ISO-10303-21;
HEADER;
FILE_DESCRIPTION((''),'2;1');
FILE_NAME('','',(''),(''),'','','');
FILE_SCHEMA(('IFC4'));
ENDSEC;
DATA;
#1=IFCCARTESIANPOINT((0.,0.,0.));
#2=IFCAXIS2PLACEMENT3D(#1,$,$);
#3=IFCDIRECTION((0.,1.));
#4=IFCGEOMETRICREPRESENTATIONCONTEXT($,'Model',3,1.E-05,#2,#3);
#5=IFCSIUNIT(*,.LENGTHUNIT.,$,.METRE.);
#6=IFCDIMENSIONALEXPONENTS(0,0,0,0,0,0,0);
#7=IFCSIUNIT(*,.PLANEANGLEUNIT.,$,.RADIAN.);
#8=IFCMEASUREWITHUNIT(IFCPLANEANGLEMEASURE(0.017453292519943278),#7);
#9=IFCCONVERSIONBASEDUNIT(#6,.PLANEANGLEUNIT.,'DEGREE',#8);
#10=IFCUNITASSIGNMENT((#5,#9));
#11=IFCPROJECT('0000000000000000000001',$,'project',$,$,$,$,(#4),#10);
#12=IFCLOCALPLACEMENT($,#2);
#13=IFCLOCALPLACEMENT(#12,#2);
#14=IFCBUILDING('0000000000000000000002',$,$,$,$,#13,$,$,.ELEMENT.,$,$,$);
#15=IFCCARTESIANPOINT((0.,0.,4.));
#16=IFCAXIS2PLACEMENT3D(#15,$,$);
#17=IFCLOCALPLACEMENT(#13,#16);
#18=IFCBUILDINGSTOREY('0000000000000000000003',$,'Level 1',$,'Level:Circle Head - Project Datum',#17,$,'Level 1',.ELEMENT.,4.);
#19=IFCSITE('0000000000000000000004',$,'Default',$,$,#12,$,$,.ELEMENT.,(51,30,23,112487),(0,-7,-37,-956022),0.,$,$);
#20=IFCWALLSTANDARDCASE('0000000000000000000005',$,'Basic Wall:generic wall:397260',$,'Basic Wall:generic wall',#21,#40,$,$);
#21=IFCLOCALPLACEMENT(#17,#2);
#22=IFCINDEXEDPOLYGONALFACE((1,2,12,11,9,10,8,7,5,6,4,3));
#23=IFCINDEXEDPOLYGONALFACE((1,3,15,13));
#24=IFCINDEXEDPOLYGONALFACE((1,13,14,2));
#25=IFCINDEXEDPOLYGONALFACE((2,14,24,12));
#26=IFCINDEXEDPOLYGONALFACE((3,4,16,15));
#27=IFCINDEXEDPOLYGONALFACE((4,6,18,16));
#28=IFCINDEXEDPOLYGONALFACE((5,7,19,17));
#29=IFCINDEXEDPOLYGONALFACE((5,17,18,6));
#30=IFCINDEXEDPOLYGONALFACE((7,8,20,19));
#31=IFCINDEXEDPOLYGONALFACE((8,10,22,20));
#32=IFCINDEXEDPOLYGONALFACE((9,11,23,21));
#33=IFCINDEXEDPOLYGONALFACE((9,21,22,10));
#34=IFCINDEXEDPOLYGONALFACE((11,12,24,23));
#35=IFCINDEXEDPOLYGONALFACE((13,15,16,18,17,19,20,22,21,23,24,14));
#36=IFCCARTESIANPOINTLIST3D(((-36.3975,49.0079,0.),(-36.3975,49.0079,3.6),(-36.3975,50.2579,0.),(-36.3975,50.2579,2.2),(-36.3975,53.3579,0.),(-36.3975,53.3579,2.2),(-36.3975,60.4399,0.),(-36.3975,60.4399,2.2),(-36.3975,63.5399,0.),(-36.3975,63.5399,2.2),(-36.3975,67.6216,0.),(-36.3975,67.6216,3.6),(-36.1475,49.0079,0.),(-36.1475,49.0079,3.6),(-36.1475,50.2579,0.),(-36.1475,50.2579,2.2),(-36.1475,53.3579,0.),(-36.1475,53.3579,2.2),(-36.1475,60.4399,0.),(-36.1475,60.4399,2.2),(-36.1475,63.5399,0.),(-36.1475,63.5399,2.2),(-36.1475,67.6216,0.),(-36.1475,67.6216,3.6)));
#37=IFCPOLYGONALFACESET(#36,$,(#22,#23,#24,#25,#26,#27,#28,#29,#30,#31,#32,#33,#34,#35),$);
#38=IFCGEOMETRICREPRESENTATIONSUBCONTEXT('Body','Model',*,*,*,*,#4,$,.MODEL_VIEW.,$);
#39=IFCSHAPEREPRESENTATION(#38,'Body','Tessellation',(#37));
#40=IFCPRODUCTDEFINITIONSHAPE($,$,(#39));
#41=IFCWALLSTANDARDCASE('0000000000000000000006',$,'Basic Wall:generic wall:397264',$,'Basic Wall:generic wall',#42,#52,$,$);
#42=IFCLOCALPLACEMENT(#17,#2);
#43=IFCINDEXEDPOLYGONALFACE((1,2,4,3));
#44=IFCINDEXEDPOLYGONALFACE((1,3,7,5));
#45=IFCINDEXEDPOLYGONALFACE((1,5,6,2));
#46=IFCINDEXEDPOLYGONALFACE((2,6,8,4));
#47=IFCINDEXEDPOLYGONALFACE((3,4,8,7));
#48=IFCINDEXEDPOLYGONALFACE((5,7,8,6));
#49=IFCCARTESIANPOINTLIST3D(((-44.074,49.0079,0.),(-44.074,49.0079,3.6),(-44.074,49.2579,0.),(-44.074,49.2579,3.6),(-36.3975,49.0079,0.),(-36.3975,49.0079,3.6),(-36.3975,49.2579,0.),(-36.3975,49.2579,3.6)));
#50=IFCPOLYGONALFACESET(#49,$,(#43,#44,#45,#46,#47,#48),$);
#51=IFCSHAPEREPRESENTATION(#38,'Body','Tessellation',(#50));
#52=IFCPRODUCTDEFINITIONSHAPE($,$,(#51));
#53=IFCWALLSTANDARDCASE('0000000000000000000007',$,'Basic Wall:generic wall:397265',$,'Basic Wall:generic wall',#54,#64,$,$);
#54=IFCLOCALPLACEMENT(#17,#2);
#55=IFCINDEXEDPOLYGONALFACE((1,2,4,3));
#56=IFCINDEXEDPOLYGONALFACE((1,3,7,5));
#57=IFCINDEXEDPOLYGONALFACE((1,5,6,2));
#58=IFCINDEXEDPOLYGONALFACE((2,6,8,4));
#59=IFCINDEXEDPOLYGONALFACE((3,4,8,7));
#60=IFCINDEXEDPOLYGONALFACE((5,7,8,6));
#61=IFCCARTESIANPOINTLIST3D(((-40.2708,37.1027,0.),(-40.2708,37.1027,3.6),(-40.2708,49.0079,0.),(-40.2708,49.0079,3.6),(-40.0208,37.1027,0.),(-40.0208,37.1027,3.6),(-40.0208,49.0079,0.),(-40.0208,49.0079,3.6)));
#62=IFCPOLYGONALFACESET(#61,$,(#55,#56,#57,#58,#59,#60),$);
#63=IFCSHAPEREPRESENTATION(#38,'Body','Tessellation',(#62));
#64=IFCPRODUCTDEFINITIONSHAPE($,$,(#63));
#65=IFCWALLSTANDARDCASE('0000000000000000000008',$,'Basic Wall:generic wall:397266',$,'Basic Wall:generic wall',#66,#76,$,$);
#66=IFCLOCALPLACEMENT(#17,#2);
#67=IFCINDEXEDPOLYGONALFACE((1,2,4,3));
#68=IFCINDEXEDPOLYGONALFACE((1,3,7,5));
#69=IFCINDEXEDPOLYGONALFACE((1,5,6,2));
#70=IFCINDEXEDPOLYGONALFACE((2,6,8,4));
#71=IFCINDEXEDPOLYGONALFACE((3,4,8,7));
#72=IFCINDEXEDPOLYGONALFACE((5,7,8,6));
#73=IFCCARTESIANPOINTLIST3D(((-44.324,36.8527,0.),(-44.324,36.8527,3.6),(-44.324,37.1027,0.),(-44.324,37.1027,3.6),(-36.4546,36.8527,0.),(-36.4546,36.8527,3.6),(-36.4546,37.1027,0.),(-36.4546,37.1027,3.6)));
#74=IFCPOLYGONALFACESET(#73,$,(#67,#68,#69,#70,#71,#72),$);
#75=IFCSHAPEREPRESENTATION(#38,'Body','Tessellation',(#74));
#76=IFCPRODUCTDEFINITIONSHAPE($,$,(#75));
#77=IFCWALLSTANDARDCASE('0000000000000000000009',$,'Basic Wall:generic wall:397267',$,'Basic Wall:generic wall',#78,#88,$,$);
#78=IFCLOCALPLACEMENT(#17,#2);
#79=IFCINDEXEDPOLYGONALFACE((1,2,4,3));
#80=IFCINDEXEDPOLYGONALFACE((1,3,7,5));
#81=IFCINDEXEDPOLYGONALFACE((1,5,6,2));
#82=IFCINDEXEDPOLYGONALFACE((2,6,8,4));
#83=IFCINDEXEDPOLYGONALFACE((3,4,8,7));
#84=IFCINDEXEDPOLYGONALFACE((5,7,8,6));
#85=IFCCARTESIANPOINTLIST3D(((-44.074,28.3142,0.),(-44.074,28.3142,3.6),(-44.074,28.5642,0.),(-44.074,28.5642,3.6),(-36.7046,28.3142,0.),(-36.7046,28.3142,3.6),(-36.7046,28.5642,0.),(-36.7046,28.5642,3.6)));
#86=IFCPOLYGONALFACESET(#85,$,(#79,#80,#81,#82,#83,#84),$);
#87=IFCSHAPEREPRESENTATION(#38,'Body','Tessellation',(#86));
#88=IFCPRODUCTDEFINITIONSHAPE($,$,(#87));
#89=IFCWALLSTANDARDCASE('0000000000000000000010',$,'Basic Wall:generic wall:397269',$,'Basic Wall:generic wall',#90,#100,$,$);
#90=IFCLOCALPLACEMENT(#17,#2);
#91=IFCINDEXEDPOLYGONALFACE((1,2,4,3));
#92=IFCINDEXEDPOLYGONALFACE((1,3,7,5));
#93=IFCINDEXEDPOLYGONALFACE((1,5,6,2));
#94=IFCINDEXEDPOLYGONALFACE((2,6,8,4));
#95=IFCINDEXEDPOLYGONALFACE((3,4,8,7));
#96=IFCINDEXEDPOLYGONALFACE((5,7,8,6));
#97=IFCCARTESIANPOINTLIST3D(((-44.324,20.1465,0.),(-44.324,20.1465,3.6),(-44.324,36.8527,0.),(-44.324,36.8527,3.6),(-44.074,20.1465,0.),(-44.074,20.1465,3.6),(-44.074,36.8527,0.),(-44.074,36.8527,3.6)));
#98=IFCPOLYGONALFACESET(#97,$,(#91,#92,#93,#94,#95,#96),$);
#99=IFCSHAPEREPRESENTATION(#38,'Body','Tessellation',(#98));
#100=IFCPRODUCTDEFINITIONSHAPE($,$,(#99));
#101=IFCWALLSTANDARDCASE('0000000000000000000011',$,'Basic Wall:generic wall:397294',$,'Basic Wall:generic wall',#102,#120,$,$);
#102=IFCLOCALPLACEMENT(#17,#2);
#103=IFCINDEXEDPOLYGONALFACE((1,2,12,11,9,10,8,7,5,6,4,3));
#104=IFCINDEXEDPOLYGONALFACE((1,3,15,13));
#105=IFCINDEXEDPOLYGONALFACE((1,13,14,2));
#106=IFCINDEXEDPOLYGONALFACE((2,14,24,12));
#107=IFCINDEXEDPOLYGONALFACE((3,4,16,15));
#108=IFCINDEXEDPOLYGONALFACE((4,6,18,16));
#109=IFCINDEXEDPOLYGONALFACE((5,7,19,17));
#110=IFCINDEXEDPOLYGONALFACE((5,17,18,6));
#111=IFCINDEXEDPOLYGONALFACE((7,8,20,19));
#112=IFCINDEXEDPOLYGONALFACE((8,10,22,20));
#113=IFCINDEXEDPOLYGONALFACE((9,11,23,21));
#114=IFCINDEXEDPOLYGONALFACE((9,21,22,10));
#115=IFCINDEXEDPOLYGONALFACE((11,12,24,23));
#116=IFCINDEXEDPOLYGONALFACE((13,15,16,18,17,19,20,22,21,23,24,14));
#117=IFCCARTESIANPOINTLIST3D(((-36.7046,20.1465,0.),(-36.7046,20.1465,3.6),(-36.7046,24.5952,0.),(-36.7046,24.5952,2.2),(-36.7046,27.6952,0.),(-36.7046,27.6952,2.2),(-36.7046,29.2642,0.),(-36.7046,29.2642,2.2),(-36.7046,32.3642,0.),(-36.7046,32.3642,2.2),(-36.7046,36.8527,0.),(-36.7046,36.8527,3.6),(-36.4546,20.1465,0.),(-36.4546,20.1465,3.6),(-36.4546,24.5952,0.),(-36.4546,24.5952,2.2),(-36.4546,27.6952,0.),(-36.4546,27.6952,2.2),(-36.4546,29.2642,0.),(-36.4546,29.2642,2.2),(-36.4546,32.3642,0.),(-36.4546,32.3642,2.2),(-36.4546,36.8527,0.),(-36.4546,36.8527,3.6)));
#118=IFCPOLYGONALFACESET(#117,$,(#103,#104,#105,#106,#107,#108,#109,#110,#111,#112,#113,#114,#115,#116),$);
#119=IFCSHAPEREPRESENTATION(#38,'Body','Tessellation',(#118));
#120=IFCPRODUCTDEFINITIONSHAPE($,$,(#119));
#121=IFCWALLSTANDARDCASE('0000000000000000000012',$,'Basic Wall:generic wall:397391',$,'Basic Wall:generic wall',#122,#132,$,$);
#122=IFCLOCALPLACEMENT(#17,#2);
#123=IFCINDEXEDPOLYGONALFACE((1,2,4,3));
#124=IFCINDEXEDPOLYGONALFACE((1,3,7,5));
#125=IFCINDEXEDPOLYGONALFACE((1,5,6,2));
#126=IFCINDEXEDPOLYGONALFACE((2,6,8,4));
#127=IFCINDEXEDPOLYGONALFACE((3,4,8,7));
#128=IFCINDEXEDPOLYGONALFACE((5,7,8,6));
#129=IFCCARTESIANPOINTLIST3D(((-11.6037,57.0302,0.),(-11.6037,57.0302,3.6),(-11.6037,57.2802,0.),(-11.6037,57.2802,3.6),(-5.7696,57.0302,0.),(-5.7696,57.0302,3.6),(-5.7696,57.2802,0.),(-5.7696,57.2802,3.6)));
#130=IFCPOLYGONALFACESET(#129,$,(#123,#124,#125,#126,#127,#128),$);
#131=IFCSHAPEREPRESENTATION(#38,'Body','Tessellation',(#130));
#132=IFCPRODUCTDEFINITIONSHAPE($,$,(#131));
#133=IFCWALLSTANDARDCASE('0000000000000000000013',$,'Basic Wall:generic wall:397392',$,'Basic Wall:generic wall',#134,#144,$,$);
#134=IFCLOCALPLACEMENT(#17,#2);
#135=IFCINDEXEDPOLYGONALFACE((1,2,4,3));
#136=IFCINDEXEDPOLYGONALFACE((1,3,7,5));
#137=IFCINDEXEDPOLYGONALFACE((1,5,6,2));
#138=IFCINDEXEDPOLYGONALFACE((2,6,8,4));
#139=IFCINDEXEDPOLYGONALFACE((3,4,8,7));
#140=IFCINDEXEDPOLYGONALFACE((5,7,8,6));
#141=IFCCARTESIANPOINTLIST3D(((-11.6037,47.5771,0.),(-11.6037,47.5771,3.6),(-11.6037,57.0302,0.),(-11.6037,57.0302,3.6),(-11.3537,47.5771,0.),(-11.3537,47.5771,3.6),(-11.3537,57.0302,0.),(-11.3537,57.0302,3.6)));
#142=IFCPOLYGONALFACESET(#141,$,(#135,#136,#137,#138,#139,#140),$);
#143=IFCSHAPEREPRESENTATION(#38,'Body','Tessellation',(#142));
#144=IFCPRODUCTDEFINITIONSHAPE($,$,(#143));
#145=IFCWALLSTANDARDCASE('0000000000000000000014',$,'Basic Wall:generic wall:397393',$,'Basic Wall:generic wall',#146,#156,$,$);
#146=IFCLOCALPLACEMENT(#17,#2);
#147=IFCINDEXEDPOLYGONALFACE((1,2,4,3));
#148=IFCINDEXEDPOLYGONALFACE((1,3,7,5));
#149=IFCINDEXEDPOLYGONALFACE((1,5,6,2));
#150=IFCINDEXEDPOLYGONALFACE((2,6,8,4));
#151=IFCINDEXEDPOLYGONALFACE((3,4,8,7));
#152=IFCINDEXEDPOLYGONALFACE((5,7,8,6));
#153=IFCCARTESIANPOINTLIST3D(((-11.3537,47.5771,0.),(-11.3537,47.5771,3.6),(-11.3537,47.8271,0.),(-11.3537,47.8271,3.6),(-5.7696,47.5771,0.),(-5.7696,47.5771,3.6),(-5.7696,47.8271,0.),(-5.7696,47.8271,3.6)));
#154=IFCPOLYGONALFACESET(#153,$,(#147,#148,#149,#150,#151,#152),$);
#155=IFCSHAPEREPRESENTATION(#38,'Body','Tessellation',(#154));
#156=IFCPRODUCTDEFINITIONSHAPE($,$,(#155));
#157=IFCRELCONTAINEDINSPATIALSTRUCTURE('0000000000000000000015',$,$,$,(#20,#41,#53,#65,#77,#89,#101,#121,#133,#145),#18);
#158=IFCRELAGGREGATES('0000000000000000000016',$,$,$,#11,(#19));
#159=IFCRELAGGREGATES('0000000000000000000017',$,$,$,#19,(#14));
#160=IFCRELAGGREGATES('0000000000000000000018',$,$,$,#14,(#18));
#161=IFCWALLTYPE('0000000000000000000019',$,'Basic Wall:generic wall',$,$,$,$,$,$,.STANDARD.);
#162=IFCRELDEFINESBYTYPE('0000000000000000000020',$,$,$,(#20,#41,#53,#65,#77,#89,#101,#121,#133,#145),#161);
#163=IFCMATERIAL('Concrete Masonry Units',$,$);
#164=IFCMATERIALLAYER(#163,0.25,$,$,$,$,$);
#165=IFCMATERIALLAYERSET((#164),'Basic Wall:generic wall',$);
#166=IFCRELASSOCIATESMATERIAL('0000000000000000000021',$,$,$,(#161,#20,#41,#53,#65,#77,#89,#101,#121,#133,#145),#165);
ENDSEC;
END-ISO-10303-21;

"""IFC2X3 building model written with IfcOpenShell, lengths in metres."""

from ifc_helpers import new_model, entity, si_unit, converted_unit, direction, frame, frame_2d, origin, place, context, subcontext, project, spatial, rectangle, extrude, material, layer, layer_set, layer_usage, type_object, element, save


model = new_model("IFC2X3")

# Units and contexts
model_context = context("Model", 3, precision=1e-05, world=origin(), true_north=direction((0.0, 1.0)))
body_context = subcontext(model_context, "Body", "Model", "MODEL_VIEW")
ifc_project = project(units=[si_unit("LENGTHUNIT", "METRE"), converted_unit("PLANEANGLEUNIT", "DEGREE", entity("IfcPlaneAngleMeasure", 0.017453292519943278), si_unit("PLANEANGLEUNIT", "RADIAN"), dimensions=[0, 0, 0, 0, 0, 0, 0])], contexts=[model_context])

# Site, building, storey
site_placement = place(None, origin())
site = spatial("IfcSite", under=ifc_project, at=site_placement, Name="Default", CompositionType="ELEMENT", RefLatitude=(51, 30, 23, 112487), RefLongitude=(0, -7, -37, -956022), RefElevation=0.0)
building_placement = place(site_placement, origin())
building = spatial("IfcBuilding", under=site, at=building_placement, CompositionType="ELEMENT")
storey_placement = place(building_placement, frame((0.0, 0.0, 4.0)))
storey = spatial("IfcBuildingStorey", under=building, at=storey_placement, Name="Level 1", ObjectType="Level:Circle Head - Project Datum", LongName="Level 1", CompositionType="ELEMENT", Elevation=4.0)

# Wall, openings
ifc_material = material(Name="Concrete Masonry Units")
ifc_layer = layer(ifc_material, 0.25)
ifc_layer_set = layer_set([ifc_layer], Name="Basic Wall:generic wall")
ifc_layer_usage_1 = layer_usage(ifc_layer_set, "AXIS2", "NEGATIVE", 0.125)
wall_type = type_object("IfcWallType", Name="Basic Wall:generic wall", PredefinedType="STANDARD", material=ifc_layer_set)
wall_1_placement = place(storey_placement, frame((-36.2725, 49.0079, 0.0), z_axis=(0.0, 0.0, 1.0), x_axis=(0.0, 1.0, 0.0)))
wall_1 = element("IfcWallStandardCase", 1, at=wall_1_placement, inside=storey, type_object=wall_type, material=ifc_layer_usage_1, Name="Basic Wall:generic wall:397260", ObjectType="Basic Wall:generic wall", context=body_context, shape_type="SweptSolid", body=[
    extrude(rectangle(XDim=18.6137, YDim=0.25, at=frame_2d((9.3069, 0.0), x_axis=(-1.0, 0.0))), origin(), (0.0, 0.0, 1.0), 3.6),
])
opening_1_placement = place(wall_1_placement, frame((11.432, -0.125, 0.0)))
element("IfcOpeningElement", 2, at=opening_1_placement, cuts=wall_1, ObjectType="Opening", context=body_context, shape_type="SweptSolid", body=[
    extrude(rectangle(XDim=2.2, YDim=3.1, at=frame_2d((1.1, 1.55), x_axis=(1.0, 0.0))), frame((0.0, 0.0, 0.0), z_axis=(0.0, 1.0, 0.0), x_axis=(0.0, 0.0, 1.0)), (0.0, 0.0, 1.0), 0.25),
])
opening_2_placement = place(wall_1_placement, frame((1.25, -0.125, 0.0)))
element("IfcOpeningElement", 3, at=opening_2_placement, cuts=wall_1, ObjectType="Opening", context=body_context, shape_type="SweptSolid", body=[
    extrude(rectangle(XDim=2.2, YDim=3.1, at=frame_2d((1.1, 1.55), x_axis=(1.0, 0.0))), frame((0.0, 0.0, 0.0), z_axis=(0.0, 1.0, 0.0), x_axis=(0.0, 0.0, 1.0)), (0.0, 0.0, 1.0), 0.25),
])

# Walls
ifc_layer_usage_2 = layer_usage(ifc_layer_set, "AXIS2", "NEGATIVE", 0.125)
wall_2_placement = place(storey_placement, frame((-44.074, 49.1329, 0.0)))
element("IfcWallStandardCase", 4, at=wall_2_placement, inside=storey, type_object=wall_type, material=ifc_layer_usage_2, Name="Basic Wall:generic wall:397264", ObjectType="Basic Wall:generic wall", context=body_context, shape_type="SweptSolid", body=[
    extrude(rectangle(XDim=7.6765, YDim=0.25, at=frame_2d((3.8382, 0.0), x_axis=(-1.0, 0.0))), origin(), (0.0, 0.0, 1.0), 3.6),
])
ifc_layer_usage_3 = layer_usage(ifc_layer_set, "AXIS2", "NEGATIVE", 0.125)
wall_3_placement = place(storey_placement, frame((-40.1458, 49.0079, 0.0), z_axis=(0.0, 0.0, 1.0), x_axis=(0.0, -1.0, 0.0)))
element("IfcWallStandardCase", 5, at=wall_3_placement, inside=storey, type_object=wall_type, material=ifc_layer_usage_3, Name="Basic Wall:generic wall:397265", ObjectType="Basic Wall:generic wall", context=body_context, shape_type="SweptSolid", body=[
    extrude(rectangle(XDim=11.9052, YDim=0.25, at=frame_2d((5.9526, 0.0), x_axis=(-1.0, 0.0))), origin(), (0.0, 0.0, 1.0), 3.6),
])
ifc_layer_usage_4 = layer_usage(ifc_layer_set, "AXIS2", "NEGATIVE", 0.125)
wall_4_placement = place(storey_placement, frame((-36.4546, 36.9777, 0.0), z_axis=(0.0, 0.0, 1.0), x_axis=(-1.0, 0.0, 0.0)))
element("IfcWallStandardCase", 6, at=wall_4_placement, inside=storey, type_object=wall_type, material=ifc_layer_usage_4, Name="Basic Wall:generic wall:397266", ObjectType="Basic Wall:generic wall", context=body_context, shape_type="SweptSolid", body=[
    extrude(rectangle(XDim=7.8694, YDim=0.25, at=frame_2d((3.9347, 0.0), x_axis=(-1.0, 0.0))), origin(), (0.0, 0.0, 1.0), 3.6),
])
ifc_layer_usage_5 = layer_usage(ifc_layer_set, "AXIS2", "NEGATIVE", 0.125)
wall_5_placement = place(storey_placement, frame((-36.7046, 28.4392, 0.0), z_axis=(0.0, 0.0, 1.0), x_axis=(-1.0, 0.0, 0.0)))
element("IfcWallStandardCase", 7, at=wall_5_placement, inside=storey, type_object=wall_type, material=ifc_layer_usage_5, Name="Basic Wall:generic wall:397267", ObjectType="Basic Wall:generic wall", context=body_context, shape_type="SweptSolid", body=[
    extrude(rectangle(XDim=7.3694, YDim=0.25, at=frame_2d((3.6847, 0.0), x_axis=(-1.0, 0.0))), origin(), (0.0, 0.0, 1.0), 3.6),
])
ifc_layer_usage_6 = layer_usage(ifc_layer_set, "AXIS2", "NEGATIVE", 0.125)
wall_6_placement = place(storey_placement, frame((-44.199, 36.8527, 0.0), z_axis=(0.0, 0.0, 1.0), x_axis=(0.0, -1.0, 0.0)))
element("IfcWallStandardCase", 8, at=wall_6_placement, inside=storey, type_object=wall_type, material=ifc_layer_usage_6, Name="Basic Wall:generic wall:397269", ObjectType="Basic Wall:generic wall", context=body_context, shape_type="SweptSolid", body=[
    extrude(rectangle(XDim=16.7062, YDim=0.25, at=frame_2d((8.3531, 0.0), x_axis=(-1.0, 0.0))), origin(), (0.0, 0.0, 1.0), 3.6),
])

# Wall, openings
ifc_layer_usage_7 = layer_usage(ifc_layer_set, "AXIS2", "NEGATIVE", 0.125)
wall_7_placement = place(storey_placement, frame((-36.5796, 36.8527, 0.0), z_axis=(0.0, 0.0, 1.0), x_axis=(0.0, -1.0, 0.0)))
wall_7 = element("IfcWallStandardCase", 9, at=wall_7_placement, inside=storey, type_object=wall_type, material=ifc_layer_usage_7, Name="Basic Wall:generic wall:397294", ObjectType="Basic Wall:generic wall", context=body_context, shape_type="SweptSolid", body=[
    extrude(rectangle(XDim=16.7062, YDim=0.25, at=frame_2d((8.3531, 0.0), x_axis=(-1.0, 0.0))), origin(), (0.0, 0.0, 1.0), 3.6),
])
opening_3_placement = place(wall_7_placement, frame((7.5885, 0.125, 0.0)))
element("IfcOpeningElement", 10, at=opening_3_placement, cuts=wall_7, ObjectType="Opening", context=body_context, shape_type="SweptSolid", body=[
    extrude(rectangle(XDim=2.2, YDim=3.1, at=frame_2d((1.1, 1.55), x_axis=(1.0, 0.0))), frame((0.0, 0.0, 0.0), z_axis=(0.0, -1.0, 0.0), x_axis=(0.0, 0.0, 1.0)), (0.0, 0.0, 1.0), 0.25),
])
opening_4_placement = place(wall_7_placement, frame((12.2575, 0.125, 0.0)))
element("IfcOpeningElement", 11, at=opening_4_placement, cuts=wall_7, ObjectType="Opening", context=body_context, shape_type="SweptSolid", body=[
    extrude(rectangle(XDim=2.2, YDim=3.1, at=frame_2d((1.1, 1.55), x_axis=(1.0, 0.0))), frame((0.0, 0.0, 0.0), z_axis=(0.0, -1.0, 0.0), x_axis=(0.0, 0.0, 1.0)), (0.0, 0.0, 1.0), 0.25),
])

# Walls
ifc_layer_usage_8 = layer_usage(ifc_layer_set, "AXIS2", "NEGATIVE", 0.125)
wall_8_placement = place(storey_placement, frame((-11.6037, 57.1552, 0.0)))
element("IfcWallStandardCase", 12, at=wall_8_placement, inside=storey, type_object=wall_type, material=ifc_layer_usage_8, Name="Basic Wall:generic wall:397391", ObjectType="Basic Wall:generic wall", context=body_context, shape_type="SweptSolid", body=[
    extrude(rectangle(XDim=5.8341, YDim=0.25, at=frame_2d((2.9171, 0.0), x_axis=(-1.0, 0.0))), origin(), (0.0, 0.0, 1.0), 3.6),
])
ifc_layer_usage_9 = layer_usage(ifc_layer_set, "AXIS2", "NEGATIVE", 0.125)
wall_9_placement = place(storey_placement, frame((-11.4787, 47.5771, 0.0), z_axis=(0.0, 0.0, 1.0), x_axis=(0.0, 1.0, 0.0)))
element("IfcWallStandardCase", 13, at=wall_9_placement, inside=storey, type_object=wall_type, material=ifc_layer_usage_9, Name="Basic Wall:generic wall:397392", ObjectType="Basic Wall:generic wall", context=body_context, shape_type="SweptSolid", body=[
    extrude(rectangle(XDim=9.4531, YDim=0.25, at=frame_2d((4.7265, 0.0), x_axis=(-1.0, 0.0))), origin(), (0.0, 0.0, 1.0), 3.6),
])
ifc_layer_usage_10 = layer_usage(ifc_layer_set, "AXIS2", "NEGATIVE", 0.125)
wall_10_placement = place(storey_placement, frame((-5.7696, 47.7021, 0.0), z_axis=(0.0, 0.0, 1.0), x_axis=(-1.0, 0.0, 0.0)))
element("IfcWallStandardCase", 14, at=wall_10_placement, inside=storey, type_object=wall_type, material=ifc_layer_usage_10, Name="Basic Wall:generic wall:397393", ObjectType="Basic Wall:generic wall", context=body_context, shape_type="SweptSolid", body=[
    extrude(rectangle(XDim=5.5841, YDim=0.25, at=frame_2d((2.7921, 0.0), x_axis=(-1.0, 0.0))), origin(), (0.0, 0.0, 1.0), 3.6),
])

save(model, "model.ifc")
